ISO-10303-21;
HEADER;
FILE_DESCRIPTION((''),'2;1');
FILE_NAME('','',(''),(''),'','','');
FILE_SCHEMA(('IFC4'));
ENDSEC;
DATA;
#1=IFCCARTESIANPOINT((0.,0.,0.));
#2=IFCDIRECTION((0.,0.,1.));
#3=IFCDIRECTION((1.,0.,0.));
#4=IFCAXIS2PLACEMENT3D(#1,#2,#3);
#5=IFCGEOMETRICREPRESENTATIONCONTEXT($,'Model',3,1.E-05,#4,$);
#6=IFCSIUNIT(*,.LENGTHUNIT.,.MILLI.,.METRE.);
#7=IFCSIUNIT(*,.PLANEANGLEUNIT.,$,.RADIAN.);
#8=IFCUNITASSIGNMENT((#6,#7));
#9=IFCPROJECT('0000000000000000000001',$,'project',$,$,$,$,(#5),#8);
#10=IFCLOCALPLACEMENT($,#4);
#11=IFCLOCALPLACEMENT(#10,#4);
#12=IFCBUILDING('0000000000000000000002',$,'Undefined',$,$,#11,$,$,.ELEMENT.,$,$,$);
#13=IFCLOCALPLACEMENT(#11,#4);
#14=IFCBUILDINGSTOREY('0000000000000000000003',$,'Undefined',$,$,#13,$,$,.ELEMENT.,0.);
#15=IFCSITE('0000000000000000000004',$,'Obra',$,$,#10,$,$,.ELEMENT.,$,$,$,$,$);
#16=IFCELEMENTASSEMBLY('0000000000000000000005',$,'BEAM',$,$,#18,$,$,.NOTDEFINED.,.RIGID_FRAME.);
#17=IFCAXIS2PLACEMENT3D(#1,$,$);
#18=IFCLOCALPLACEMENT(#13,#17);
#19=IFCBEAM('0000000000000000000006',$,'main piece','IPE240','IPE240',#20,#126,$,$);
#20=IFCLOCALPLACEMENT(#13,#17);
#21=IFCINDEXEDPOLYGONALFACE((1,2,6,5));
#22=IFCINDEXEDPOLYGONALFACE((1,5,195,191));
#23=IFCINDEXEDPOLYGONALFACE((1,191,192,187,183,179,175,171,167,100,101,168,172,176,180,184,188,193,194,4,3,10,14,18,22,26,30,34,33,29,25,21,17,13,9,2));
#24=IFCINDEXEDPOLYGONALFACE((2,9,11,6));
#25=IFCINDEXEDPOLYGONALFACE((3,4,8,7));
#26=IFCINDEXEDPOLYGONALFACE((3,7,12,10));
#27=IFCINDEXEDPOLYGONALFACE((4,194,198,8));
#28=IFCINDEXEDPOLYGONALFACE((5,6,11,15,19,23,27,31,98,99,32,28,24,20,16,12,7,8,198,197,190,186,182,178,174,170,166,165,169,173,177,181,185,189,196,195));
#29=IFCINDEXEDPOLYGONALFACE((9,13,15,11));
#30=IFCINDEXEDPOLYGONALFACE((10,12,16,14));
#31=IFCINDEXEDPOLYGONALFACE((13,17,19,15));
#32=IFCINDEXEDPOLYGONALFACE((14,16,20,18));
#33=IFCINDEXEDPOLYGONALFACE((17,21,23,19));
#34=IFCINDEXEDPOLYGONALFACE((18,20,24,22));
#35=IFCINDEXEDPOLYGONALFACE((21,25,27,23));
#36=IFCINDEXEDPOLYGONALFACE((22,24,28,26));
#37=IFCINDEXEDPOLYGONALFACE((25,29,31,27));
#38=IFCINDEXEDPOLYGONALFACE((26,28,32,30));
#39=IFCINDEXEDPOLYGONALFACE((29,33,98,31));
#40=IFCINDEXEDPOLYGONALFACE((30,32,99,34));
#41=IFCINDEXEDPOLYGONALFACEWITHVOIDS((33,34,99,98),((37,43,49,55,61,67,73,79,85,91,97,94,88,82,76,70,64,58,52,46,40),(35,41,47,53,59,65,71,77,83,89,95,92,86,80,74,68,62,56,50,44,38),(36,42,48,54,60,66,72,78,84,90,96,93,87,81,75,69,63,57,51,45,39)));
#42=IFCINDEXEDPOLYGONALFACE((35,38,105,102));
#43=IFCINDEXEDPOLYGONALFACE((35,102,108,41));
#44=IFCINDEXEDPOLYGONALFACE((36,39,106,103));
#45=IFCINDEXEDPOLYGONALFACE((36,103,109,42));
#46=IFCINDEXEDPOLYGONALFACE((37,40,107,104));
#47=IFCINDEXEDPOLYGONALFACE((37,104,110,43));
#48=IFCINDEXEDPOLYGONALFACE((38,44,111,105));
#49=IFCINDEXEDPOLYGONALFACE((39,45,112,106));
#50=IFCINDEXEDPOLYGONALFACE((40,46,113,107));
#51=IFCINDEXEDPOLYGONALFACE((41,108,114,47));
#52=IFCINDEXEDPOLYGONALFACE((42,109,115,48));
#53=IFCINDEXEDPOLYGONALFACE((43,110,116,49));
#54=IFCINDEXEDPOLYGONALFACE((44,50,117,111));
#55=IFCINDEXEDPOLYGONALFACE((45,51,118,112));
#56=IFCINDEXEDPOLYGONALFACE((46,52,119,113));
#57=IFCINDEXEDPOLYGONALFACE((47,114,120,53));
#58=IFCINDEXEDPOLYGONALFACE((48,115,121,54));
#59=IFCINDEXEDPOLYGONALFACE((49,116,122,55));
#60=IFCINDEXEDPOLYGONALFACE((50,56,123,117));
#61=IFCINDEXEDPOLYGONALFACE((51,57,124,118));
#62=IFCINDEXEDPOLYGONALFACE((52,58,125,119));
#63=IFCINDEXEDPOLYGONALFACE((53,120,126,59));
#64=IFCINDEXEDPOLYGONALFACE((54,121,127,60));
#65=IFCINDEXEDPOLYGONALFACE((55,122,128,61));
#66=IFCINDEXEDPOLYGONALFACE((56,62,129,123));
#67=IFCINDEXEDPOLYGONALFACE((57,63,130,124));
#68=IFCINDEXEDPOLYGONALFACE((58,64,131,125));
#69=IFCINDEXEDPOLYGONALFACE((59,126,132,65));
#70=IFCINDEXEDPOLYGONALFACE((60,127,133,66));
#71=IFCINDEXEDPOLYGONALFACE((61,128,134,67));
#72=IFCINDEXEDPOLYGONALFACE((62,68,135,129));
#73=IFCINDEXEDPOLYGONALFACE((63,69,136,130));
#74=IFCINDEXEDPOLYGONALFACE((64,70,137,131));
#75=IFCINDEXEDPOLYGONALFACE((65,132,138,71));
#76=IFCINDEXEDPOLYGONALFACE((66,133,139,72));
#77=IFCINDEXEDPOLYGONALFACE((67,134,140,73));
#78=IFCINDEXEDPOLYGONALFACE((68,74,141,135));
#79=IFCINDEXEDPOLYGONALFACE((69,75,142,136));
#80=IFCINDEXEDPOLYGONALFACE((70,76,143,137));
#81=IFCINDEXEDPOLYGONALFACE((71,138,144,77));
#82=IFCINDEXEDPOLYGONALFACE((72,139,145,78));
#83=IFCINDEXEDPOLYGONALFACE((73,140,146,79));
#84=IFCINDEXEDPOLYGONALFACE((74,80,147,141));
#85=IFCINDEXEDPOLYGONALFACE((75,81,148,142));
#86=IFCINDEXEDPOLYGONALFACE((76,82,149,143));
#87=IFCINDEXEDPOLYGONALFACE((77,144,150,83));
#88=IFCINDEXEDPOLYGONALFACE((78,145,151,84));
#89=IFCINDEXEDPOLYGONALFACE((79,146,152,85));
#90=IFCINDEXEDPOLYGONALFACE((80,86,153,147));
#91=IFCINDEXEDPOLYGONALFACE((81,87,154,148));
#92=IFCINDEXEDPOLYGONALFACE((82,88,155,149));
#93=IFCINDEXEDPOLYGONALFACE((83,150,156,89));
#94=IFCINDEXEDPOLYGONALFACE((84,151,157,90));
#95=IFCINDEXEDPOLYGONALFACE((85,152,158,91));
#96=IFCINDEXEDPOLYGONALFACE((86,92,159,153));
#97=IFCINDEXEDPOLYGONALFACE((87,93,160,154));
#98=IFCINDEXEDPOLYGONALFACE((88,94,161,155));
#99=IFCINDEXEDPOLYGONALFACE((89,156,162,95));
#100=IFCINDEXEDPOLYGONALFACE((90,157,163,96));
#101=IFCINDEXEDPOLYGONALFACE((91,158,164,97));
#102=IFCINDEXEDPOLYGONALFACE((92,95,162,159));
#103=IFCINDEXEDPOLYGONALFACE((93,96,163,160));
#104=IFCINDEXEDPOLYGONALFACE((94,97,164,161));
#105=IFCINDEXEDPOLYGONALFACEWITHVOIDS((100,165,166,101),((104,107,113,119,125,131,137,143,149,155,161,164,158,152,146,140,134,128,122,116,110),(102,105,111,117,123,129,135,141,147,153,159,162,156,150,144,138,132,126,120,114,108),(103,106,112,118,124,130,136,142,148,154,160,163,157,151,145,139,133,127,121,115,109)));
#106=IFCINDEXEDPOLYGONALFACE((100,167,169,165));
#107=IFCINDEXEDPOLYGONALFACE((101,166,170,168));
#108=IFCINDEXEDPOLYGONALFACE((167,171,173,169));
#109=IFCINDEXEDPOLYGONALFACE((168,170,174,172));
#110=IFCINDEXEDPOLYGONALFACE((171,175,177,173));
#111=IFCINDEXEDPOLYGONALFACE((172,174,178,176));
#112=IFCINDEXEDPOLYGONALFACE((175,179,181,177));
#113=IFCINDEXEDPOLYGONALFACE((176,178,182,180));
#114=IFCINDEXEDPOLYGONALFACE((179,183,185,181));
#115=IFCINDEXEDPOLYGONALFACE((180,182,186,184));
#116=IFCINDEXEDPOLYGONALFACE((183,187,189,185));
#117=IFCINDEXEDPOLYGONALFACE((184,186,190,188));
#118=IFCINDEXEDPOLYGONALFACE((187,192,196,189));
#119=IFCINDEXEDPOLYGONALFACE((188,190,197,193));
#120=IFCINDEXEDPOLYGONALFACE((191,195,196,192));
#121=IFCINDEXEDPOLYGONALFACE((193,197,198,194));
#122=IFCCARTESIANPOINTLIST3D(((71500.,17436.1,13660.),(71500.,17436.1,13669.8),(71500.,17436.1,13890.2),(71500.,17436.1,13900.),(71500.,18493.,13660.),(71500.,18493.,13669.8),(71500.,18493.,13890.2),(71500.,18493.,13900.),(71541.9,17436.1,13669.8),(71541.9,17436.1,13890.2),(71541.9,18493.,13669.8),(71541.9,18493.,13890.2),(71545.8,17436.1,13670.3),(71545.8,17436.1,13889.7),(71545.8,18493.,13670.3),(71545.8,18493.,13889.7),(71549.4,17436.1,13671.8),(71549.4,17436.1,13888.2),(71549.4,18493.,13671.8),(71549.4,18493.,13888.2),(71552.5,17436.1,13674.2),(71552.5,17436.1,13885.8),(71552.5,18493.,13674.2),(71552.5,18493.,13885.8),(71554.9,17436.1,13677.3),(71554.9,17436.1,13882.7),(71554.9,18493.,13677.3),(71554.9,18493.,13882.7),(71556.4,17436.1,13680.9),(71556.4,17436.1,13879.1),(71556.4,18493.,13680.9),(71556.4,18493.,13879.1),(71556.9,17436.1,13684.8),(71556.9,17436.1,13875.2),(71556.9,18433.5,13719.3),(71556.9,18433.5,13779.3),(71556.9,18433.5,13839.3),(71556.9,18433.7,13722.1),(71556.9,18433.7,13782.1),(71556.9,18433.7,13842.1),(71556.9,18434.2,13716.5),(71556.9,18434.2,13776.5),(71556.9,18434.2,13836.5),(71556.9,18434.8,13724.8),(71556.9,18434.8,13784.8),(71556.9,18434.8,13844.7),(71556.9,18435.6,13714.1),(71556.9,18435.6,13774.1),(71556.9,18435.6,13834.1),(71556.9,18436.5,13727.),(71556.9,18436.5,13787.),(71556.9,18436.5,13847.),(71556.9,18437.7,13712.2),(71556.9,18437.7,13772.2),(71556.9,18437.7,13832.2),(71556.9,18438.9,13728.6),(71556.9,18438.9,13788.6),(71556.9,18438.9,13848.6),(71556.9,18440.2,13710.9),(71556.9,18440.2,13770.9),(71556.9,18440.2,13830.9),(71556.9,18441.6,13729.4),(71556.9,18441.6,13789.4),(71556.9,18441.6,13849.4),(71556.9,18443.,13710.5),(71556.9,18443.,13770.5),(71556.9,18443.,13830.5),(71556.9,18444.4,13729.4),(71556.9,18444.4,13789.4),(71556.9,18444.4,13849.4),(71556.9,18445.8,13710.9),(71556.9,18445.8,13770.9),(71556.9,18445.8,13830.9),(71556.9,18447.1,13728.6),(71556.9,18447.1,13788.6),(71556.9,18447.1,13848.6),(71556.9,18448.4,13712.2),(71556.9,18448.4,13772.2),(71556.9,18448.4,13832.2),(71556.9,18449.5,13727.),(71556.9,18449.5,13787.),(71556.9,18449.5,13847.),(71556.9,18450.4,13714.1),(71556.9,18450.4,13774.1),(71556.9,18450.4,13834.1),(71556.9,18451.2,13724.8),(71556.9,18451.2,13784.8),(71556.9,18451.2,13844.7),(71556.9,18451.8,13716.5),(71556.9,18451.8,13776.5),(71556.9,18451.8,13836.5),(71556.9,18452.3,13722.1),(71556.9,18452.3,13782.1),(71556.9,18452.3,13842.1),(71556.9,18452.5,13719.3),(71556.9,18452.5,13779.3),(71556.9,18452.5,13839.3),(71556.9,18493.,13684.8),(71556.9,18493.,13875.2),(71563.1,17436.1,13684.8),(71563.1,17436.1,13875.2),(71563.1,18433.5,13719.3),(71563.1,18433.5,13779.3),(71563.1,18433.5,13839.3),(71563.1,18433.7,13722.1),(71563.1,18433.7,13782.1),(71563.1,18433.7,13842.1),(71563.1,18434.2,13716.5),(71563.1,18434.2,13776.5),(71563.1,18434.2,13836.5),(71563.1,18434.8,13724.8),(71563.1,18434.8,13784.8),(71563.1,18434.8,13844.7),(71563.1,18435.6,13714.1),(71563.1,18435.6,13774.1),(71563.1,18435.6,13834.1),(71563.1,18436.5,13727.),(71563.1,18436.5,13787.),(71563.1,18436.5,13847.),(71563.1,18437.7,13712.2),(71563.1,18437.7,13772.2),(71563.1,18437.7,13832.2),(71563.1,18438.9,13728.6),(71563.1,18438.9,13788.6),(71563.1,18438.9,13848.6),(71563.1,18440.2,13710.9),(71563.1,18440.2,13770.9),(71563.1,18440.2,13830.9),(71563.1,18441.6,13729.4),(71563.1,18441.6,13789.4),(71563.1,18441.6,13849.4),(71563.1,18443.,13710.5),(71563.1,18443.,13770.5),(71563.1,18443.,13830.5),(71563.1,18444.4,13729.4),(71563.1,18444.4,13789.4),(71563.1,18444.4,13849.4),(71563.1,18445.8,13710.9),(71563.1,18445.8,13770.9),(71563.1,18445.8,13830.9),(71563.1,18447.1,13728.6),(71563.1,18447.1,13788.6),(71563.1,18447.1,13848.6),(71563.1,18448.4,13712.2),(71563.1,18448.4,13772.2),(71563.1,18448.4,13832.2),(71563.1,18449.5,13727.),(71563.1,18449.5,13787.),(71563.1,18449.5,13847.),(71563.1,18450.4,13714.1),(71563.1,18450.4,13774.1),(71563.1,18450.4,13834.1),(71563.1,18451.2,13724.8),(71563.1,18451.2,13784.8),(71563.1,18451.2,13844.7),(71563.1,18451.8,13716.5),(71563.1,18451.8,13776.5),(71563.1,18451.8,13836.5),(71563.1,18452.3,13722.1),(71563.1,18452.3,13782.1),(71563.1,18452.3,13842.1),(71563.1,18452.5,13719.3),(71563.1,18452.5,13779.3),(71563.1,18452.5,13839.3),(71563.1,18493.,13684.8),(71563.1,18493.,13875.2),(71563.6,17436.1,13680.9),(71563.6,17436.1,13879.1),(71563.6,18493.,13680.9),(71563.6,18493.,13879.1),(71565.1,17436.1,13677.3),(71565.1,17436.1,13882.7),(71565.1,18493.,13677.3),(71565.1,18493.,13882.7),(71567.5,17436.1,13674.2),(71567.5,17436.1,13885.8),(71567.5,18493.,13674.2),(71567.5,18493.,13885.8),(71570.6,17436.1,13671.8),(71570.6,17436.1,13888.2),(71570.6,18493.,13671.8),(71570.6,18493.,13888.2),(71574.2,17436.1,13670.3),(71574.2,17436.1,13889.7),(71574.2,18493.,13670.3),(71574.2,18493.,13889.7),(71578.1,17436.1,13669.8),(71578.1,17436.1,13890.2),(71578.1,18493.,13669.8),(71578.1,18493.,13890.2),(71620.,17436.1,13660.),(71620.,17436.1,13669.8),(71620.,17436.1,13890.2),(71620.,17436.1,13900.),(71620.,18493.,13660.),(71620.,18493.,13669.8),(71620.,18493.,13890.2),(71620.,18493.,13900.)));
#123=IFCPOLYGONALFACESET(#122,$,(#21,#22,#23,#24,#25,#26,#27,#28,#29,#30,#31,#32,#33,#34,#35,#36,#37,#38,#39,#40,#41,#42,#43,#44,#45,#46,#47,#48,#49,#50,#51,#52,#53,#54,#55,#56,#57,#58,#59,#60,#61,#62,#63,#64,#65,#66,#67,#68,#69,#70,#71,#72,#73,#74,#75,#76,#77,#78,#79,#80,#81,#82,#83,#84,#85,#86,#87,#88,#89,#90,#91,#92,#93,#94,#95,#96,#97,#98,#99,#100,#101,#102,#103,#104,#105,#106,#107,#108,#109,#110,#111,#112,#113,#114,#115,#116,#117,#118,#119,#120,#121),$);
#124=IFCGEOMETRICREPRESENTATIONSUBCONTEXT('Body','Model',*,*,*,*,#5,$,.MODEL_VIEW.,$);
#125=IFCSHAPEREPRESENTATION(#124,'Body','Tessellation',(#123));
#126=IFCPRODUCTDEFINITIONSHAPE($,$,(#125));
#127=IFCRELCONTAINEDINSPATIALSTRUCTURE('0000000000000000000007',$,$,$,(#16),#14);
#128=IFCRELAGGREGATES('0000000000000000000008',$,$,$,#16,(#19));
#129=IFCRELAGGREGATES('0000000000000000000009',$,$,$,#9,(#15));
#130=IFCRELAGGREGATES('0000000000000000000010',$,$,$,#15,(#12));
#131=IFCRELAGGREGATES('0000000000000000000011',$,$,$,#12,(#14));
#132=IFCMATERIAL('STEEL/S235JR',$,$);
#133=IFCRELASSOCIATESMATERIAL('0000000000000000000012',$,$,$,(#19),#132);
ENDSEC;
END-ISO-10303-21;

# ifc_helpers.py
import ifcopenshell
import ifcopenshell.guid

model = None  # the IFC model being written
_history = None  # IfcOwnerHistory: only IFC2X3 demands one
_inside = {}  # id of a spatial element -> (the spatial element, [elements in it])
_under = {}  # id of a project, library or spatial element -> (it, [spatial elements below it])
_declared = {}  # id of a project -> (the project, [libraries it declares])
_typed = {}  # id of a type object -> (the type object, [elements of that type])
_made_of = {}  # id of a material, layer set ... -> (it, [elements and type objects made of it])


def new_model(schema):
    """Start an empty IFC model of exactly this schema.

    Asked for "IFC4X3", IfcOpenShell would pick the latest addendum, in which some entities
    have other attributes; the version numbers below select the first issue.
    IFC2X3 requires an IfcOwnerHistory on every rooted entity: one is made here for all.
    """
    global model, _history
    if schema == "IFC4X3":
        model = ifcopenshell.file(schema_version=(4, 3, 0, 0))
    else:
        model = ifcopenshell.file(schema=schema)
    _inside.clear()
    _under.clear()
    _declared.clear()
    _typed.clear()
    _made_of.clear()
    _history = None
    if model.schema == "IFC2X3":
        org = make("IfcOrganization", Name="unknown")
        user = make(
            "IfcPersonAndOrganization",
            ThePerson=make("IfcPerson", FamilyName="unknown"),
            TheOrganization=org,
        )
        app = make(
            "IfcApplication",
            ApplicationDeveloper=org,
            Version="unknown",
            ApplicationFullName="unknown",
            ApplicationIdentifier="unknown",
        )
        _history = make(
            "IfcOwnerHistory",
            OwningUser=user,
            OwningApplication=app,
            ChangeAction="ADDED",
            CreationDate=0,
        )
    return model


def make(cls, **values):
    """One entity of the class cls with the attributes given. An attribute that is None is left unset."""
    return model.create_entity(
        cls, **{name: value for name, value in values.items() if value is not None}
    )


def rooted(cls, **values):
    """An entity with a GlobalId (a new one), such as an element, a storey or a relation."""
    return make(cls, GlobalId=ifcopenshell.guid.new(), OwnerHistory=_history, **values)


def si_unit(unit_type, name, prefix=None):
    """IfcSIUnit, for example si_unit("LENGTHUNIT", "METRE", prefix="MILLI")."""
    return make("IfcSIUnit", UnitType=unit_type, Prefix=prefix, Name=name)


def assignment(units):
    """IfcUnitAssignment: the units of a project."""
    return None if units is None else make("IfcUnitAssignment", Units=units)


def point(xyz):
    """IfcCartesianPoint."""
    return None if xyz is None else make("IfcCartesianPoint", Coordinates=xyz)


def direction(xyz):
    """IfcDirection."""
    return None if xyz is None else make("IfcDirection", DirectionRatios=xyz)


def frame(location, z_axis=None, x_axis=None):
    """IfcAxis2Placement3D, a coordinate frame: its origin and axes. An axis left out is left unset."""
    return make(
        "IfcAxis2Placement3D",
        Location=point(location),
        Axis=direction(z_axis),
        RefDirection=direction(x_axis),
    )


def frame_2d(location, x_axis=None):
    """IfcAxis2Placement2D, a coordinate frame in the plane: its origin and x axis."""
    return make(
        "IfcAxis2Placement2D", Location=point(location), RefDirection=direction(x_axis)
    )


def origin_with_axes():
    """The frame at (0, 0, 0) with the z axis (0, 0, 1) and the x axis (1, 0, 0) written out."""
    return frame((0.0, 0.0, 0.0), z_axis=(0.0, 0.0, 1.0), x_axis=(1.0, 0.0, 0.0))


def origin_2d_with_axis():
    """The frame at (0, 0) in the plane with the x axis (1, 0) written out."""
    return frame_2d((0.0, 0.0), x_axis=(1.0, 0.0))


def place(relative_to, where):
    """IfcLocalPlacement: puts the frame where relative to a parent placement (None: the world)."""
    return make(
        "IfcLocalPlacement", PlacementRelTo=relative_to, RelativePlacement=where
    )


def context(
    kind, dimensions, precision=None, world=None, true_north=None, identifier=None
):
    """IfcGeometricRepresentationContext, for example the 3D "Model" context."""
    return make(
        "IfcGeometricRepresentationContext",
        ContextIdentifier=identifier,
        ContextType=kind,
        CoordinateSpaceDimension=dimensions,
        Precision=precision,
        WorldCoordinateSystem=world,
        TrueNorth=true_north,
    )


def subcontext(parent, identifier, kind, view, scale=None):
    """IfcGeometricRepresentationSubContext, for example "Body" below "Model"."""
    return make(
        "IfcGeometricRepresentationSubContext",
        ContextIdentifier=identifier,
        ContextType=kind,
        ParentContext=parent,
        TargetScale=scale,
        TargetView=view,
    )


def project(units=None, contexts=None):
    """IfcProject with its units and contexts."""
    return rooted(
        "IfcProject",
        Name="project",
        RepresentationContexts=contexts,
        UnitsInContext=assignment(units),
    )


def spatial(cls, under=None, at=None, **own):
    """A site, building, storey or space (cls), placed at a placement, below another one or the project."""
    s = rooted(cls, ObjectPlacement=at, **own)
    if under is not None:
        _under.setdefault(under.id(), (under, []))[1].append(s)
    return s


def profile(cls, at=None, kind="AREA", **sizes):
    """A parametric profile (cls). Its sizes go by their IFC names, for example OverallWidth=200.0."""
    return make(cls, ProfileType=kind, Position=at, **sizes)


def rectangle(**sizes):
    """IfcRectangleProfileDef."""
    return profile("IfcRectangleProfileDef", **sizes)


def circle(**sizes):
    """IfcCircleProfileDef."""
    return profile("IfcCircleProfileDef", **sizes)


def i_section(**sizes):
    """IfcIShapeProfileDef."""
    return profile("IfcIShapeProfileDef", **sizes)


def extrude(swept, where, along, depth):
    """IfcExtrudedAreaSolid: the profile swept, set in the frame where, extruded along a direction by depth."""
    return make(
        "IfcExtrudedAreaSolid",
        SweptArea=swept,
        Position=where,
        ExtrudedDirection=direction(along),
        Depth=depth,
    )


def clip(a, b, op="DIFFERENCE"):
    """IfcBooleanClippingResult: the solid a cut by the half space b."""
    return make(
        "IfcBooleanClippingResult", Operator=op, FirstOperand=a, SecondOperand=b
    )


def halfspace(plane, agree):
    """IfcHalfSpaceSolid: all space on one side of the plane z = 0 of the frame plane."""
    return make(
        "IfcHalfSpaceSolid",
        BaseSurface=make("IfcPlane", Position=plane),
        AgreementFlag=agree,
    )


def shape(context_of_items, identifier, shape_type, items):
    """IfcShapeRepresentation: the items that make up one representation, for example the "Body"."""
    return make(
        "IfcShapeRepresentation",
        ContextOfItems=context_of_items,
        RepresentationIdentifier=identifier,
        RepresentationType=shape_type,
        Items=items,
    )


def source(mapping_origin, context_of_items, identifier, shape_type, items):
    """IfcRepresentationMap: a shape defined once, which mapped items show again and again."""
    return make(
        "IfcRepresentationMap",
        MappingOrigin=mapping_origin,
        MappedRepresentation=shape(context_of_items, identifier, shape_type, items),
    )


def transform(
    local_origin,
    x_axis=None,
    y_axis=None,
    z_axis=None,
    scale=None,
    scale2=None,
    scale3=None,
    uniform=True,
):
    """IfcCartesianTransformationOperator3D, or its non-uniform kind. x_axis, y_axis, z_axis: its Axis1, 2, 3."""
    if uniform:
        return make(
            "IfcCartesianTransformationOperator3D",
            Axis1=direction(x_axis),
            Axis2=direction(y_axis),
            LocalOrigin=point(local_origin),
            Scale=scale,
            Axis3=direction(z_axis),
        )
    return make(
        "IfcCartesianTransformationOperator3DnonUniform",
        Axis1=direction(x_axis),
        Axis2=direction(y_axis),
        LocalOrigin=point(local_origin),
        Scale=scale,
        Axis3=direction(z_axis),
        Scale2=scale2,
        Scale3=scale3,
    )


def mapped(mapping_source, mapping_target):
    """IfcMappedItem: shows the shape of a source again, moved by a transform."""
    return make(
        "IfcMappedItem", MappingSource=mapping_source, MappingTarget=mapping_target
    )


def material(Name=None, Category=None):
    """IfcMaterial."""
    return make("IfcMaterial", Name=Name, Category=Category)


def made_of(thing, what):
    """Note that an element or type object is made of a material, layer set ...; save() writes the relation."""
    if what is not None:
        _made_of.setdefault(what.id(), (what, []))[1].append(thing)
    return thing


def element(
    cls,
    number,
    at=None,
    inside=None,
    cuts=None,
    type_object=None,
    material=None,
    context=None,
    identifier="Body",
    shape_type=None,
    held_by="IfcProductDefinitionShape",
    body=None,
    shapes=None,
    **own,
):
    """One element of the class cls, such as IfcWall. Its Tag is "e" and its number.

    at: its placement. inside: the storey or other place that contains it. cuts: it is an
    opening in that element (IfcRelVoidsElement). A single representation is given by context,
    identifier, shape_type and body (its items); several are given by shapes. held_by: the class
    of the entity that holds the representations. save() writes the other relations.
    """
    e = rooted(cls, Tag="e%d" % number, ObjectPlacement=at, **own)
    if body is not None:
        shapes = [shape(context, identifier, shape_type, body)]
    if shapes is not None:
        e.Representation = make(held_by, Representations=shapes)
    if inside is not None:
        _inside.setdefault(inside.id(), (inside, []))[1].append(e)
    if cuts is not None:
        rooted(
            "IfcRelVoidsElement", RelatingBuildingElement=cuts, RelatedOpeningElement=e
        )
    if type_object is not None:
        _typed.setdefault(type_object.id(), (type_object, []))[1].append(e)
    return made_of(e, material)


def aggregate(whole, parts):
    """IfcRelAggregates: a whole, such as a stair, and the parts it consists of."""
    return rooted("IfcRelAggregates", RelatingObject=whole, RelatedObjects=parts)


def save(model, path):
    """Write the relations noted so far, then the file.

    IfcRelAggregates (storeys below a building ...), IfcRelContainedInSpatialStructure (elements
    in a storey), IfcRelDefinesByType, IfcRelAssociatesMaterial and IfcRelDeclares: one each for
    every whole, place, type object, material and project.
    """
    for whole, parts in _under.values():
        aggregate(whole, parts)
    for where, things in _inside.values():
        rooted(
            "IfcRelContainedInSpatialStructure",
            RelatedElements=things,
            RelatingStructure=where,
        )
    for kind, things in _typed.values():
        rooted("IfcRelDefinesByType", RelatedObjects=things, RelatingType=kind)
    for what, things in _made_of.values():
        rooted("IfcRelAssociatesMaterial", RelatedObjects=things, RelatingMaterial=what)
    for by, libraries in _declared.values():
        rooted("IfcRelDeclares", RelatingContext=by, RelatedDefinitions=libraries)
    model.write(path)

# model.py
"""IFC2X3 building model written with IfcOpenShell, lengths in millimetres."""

from ifc_helpers import new_model, si_unit, frame, origin_with_axes, origin_2d_with_axis, place, context, subcontext, project, spatial, rectangle, circle, i_section, extrude, clip, halfspace, source, transform, mapped, material, element, aggregate, save


model = new_model("IFC2X3")

# Units and contexts
model_context = context("Model", 3, precision=1e-05, world=origin_with_axes())
body_context = subcontext(model_context, "Body", "Model", "MODEL_VIEW")
ifc_project = project(units=[si_unit("LENGTHUNIT", "METRE", prefix="MILLI"), si_unit("PLANEANGLEUNIT", "RADIAN")], contexts=[model_context])

# Site, building, storey
site_placement = place(None, origin_with_axes())
site = spatial("IfcSite", under=ifc_project, at=site_placement, Name="Obra", CompositionType="ELEMENT")
building_placement = place(site_placement, origin_with_axes())
building = spatial("IfcBuilding", under=site, at=building_placement, Name="Undefined", CompositionType="ELEMENT")
storey_placement = place(building_placement, origin_with_axes())
storey = spatial("IfcBuildingStorey", under=building, at=storey_placement, Name="Undefined", CompositionType="ELEMENT", Elevation=0.0)

# Element assembly, beam, openings
assembly_1_placement = place(storey_placement, origin_with_axes())
assembly_1 = element("IfcElementAssembly", 1, at=assembly_1_placement, inside=storey, Name="BEAM", AssemblyPlace="NOTDEFINED", PredefinedType="RIGID_FRAME")
ifc_material_1 = material(Name="STEEL/S235JR")
beam_1_placement = place(assembly_1_placement, frame((71560.0, 17345.4, 13780.0), z_axis=(0.0, 0.0, 1.0), x_axis=(0.0, 1.0, 0.0)))
beam_1 = element("IfcBeam", 2, at=beam_1_placement, material=ifc_material_1, Name="main piece", Description="IPE240", ObjectType="IPE240", context=body_context, shape_type="Clipping", body=[
    clip(clip(extrude(i_section(OverallWidth=120.0, OverallDepth=240.0, WebThickness=6.2, FlangeThickness=9.8, FilletRadius=15.0, at=origin_2d_with_axis()), frame((1147.6, 0.0, 0.0), z_axis=(-1.0, 0.0, 0.0), x_axis=(0.0, -1.0, 0.0)), (0.0, 0.0, 1.0), 1147.6), halfspace(frame((90.8, 60.0, -120.0), z_axis=(-1.0, 0.0, 0.0), x_axis=(0.0, 0.0, 1.0)), False)), halfspace(frame((1147.6, 0.0, -220.0), z_axis=(-1.0, -0.000001, 0.0), x_axis=(-0.000001, 1.0, 0.0)), True)),
])
opening_1_placement = place(assembly_1_placement, frame((71560.0, 17345.4, 13780.0), z_axis=(0.0, 0.0, 1.0), x_axis=(0.0, 1.0, 0.0)))
element("IfcOpeningElement", 3, at=opening_1_placement, cuts=beam_1, ObjectType="Recess", context=body_context, shape_type="SweptSolid", body=[
    extrude(rectangle(XDim=25.8, YDim=68.9, at=origin_2d_with_axis()), frame((1182.1, 61.0, -108.1), z_axis=(0.000001, -1.0, 0.0), x_axis=(0.0, 0.0, -1.0)), (0.0, 0.0, 1.0), 122.0),
])
opening_2_placement = place(assembly_1_placement, frame((71560.0, 17345.4, 13780.0), z_axis=(0.0, 0.0, 1.0), x_axis=(0.0, 1.0, 0.0)))
element("IfcOpeningElement", 4, at=opening_2_placement, cuts=beam_1, ObjectType="Recess", context=body_context, shape_type="SweptSolid", body=[
    extrude(rectangle(XDim=25.8, YDim=68.9, at=origin_2d_with_axis()), frame((1182.1, 61.0, 108.1), z_axis=(0.000001, -1.0, 0.0), x_axis=(0.0, 0.0, -1.0)), (0.0, 0.0, 1.0), 122.0),
])
shared_shape_1 = source(origin_with_axes(), body_context, "Body", "SweptSolid", [
    extrude(circle(Radius=9.5, at=origin_2d_with_axis()), frame((0.0, -3.2, 0.0), z_axis=(0.0, 1.0, 0.0), x_axis=(1.0, 0.0, 0.0)), (0.0, 0.0, 1.0), 6.4),
])
opening_3_placement = place(assembly_1_placement, frame((71560.0, 18493.0, 13890.2), z_axis=(0.000001, -1.0, 0.0), x_axis=(0.0, 0.0, -1.0)))
element("IfcOpeningElement", 5, at=opening_3_placement, cuts=beam_1, ObjectType="Opening", context=body_context, shape_type="MappedRepresentation", body=[
    mapped(shared_shape_1, transform((170.2, 0.0, 50.0))),
    mapped(shared_shape_1, transform((110.2, 0.0, 50.0))),
    mapped(shared_shape_1, transform((50.2, 0.0, 50.0))),
])

aggregate(assembly_1, [beam_1])

save(model, "model.ifc")
